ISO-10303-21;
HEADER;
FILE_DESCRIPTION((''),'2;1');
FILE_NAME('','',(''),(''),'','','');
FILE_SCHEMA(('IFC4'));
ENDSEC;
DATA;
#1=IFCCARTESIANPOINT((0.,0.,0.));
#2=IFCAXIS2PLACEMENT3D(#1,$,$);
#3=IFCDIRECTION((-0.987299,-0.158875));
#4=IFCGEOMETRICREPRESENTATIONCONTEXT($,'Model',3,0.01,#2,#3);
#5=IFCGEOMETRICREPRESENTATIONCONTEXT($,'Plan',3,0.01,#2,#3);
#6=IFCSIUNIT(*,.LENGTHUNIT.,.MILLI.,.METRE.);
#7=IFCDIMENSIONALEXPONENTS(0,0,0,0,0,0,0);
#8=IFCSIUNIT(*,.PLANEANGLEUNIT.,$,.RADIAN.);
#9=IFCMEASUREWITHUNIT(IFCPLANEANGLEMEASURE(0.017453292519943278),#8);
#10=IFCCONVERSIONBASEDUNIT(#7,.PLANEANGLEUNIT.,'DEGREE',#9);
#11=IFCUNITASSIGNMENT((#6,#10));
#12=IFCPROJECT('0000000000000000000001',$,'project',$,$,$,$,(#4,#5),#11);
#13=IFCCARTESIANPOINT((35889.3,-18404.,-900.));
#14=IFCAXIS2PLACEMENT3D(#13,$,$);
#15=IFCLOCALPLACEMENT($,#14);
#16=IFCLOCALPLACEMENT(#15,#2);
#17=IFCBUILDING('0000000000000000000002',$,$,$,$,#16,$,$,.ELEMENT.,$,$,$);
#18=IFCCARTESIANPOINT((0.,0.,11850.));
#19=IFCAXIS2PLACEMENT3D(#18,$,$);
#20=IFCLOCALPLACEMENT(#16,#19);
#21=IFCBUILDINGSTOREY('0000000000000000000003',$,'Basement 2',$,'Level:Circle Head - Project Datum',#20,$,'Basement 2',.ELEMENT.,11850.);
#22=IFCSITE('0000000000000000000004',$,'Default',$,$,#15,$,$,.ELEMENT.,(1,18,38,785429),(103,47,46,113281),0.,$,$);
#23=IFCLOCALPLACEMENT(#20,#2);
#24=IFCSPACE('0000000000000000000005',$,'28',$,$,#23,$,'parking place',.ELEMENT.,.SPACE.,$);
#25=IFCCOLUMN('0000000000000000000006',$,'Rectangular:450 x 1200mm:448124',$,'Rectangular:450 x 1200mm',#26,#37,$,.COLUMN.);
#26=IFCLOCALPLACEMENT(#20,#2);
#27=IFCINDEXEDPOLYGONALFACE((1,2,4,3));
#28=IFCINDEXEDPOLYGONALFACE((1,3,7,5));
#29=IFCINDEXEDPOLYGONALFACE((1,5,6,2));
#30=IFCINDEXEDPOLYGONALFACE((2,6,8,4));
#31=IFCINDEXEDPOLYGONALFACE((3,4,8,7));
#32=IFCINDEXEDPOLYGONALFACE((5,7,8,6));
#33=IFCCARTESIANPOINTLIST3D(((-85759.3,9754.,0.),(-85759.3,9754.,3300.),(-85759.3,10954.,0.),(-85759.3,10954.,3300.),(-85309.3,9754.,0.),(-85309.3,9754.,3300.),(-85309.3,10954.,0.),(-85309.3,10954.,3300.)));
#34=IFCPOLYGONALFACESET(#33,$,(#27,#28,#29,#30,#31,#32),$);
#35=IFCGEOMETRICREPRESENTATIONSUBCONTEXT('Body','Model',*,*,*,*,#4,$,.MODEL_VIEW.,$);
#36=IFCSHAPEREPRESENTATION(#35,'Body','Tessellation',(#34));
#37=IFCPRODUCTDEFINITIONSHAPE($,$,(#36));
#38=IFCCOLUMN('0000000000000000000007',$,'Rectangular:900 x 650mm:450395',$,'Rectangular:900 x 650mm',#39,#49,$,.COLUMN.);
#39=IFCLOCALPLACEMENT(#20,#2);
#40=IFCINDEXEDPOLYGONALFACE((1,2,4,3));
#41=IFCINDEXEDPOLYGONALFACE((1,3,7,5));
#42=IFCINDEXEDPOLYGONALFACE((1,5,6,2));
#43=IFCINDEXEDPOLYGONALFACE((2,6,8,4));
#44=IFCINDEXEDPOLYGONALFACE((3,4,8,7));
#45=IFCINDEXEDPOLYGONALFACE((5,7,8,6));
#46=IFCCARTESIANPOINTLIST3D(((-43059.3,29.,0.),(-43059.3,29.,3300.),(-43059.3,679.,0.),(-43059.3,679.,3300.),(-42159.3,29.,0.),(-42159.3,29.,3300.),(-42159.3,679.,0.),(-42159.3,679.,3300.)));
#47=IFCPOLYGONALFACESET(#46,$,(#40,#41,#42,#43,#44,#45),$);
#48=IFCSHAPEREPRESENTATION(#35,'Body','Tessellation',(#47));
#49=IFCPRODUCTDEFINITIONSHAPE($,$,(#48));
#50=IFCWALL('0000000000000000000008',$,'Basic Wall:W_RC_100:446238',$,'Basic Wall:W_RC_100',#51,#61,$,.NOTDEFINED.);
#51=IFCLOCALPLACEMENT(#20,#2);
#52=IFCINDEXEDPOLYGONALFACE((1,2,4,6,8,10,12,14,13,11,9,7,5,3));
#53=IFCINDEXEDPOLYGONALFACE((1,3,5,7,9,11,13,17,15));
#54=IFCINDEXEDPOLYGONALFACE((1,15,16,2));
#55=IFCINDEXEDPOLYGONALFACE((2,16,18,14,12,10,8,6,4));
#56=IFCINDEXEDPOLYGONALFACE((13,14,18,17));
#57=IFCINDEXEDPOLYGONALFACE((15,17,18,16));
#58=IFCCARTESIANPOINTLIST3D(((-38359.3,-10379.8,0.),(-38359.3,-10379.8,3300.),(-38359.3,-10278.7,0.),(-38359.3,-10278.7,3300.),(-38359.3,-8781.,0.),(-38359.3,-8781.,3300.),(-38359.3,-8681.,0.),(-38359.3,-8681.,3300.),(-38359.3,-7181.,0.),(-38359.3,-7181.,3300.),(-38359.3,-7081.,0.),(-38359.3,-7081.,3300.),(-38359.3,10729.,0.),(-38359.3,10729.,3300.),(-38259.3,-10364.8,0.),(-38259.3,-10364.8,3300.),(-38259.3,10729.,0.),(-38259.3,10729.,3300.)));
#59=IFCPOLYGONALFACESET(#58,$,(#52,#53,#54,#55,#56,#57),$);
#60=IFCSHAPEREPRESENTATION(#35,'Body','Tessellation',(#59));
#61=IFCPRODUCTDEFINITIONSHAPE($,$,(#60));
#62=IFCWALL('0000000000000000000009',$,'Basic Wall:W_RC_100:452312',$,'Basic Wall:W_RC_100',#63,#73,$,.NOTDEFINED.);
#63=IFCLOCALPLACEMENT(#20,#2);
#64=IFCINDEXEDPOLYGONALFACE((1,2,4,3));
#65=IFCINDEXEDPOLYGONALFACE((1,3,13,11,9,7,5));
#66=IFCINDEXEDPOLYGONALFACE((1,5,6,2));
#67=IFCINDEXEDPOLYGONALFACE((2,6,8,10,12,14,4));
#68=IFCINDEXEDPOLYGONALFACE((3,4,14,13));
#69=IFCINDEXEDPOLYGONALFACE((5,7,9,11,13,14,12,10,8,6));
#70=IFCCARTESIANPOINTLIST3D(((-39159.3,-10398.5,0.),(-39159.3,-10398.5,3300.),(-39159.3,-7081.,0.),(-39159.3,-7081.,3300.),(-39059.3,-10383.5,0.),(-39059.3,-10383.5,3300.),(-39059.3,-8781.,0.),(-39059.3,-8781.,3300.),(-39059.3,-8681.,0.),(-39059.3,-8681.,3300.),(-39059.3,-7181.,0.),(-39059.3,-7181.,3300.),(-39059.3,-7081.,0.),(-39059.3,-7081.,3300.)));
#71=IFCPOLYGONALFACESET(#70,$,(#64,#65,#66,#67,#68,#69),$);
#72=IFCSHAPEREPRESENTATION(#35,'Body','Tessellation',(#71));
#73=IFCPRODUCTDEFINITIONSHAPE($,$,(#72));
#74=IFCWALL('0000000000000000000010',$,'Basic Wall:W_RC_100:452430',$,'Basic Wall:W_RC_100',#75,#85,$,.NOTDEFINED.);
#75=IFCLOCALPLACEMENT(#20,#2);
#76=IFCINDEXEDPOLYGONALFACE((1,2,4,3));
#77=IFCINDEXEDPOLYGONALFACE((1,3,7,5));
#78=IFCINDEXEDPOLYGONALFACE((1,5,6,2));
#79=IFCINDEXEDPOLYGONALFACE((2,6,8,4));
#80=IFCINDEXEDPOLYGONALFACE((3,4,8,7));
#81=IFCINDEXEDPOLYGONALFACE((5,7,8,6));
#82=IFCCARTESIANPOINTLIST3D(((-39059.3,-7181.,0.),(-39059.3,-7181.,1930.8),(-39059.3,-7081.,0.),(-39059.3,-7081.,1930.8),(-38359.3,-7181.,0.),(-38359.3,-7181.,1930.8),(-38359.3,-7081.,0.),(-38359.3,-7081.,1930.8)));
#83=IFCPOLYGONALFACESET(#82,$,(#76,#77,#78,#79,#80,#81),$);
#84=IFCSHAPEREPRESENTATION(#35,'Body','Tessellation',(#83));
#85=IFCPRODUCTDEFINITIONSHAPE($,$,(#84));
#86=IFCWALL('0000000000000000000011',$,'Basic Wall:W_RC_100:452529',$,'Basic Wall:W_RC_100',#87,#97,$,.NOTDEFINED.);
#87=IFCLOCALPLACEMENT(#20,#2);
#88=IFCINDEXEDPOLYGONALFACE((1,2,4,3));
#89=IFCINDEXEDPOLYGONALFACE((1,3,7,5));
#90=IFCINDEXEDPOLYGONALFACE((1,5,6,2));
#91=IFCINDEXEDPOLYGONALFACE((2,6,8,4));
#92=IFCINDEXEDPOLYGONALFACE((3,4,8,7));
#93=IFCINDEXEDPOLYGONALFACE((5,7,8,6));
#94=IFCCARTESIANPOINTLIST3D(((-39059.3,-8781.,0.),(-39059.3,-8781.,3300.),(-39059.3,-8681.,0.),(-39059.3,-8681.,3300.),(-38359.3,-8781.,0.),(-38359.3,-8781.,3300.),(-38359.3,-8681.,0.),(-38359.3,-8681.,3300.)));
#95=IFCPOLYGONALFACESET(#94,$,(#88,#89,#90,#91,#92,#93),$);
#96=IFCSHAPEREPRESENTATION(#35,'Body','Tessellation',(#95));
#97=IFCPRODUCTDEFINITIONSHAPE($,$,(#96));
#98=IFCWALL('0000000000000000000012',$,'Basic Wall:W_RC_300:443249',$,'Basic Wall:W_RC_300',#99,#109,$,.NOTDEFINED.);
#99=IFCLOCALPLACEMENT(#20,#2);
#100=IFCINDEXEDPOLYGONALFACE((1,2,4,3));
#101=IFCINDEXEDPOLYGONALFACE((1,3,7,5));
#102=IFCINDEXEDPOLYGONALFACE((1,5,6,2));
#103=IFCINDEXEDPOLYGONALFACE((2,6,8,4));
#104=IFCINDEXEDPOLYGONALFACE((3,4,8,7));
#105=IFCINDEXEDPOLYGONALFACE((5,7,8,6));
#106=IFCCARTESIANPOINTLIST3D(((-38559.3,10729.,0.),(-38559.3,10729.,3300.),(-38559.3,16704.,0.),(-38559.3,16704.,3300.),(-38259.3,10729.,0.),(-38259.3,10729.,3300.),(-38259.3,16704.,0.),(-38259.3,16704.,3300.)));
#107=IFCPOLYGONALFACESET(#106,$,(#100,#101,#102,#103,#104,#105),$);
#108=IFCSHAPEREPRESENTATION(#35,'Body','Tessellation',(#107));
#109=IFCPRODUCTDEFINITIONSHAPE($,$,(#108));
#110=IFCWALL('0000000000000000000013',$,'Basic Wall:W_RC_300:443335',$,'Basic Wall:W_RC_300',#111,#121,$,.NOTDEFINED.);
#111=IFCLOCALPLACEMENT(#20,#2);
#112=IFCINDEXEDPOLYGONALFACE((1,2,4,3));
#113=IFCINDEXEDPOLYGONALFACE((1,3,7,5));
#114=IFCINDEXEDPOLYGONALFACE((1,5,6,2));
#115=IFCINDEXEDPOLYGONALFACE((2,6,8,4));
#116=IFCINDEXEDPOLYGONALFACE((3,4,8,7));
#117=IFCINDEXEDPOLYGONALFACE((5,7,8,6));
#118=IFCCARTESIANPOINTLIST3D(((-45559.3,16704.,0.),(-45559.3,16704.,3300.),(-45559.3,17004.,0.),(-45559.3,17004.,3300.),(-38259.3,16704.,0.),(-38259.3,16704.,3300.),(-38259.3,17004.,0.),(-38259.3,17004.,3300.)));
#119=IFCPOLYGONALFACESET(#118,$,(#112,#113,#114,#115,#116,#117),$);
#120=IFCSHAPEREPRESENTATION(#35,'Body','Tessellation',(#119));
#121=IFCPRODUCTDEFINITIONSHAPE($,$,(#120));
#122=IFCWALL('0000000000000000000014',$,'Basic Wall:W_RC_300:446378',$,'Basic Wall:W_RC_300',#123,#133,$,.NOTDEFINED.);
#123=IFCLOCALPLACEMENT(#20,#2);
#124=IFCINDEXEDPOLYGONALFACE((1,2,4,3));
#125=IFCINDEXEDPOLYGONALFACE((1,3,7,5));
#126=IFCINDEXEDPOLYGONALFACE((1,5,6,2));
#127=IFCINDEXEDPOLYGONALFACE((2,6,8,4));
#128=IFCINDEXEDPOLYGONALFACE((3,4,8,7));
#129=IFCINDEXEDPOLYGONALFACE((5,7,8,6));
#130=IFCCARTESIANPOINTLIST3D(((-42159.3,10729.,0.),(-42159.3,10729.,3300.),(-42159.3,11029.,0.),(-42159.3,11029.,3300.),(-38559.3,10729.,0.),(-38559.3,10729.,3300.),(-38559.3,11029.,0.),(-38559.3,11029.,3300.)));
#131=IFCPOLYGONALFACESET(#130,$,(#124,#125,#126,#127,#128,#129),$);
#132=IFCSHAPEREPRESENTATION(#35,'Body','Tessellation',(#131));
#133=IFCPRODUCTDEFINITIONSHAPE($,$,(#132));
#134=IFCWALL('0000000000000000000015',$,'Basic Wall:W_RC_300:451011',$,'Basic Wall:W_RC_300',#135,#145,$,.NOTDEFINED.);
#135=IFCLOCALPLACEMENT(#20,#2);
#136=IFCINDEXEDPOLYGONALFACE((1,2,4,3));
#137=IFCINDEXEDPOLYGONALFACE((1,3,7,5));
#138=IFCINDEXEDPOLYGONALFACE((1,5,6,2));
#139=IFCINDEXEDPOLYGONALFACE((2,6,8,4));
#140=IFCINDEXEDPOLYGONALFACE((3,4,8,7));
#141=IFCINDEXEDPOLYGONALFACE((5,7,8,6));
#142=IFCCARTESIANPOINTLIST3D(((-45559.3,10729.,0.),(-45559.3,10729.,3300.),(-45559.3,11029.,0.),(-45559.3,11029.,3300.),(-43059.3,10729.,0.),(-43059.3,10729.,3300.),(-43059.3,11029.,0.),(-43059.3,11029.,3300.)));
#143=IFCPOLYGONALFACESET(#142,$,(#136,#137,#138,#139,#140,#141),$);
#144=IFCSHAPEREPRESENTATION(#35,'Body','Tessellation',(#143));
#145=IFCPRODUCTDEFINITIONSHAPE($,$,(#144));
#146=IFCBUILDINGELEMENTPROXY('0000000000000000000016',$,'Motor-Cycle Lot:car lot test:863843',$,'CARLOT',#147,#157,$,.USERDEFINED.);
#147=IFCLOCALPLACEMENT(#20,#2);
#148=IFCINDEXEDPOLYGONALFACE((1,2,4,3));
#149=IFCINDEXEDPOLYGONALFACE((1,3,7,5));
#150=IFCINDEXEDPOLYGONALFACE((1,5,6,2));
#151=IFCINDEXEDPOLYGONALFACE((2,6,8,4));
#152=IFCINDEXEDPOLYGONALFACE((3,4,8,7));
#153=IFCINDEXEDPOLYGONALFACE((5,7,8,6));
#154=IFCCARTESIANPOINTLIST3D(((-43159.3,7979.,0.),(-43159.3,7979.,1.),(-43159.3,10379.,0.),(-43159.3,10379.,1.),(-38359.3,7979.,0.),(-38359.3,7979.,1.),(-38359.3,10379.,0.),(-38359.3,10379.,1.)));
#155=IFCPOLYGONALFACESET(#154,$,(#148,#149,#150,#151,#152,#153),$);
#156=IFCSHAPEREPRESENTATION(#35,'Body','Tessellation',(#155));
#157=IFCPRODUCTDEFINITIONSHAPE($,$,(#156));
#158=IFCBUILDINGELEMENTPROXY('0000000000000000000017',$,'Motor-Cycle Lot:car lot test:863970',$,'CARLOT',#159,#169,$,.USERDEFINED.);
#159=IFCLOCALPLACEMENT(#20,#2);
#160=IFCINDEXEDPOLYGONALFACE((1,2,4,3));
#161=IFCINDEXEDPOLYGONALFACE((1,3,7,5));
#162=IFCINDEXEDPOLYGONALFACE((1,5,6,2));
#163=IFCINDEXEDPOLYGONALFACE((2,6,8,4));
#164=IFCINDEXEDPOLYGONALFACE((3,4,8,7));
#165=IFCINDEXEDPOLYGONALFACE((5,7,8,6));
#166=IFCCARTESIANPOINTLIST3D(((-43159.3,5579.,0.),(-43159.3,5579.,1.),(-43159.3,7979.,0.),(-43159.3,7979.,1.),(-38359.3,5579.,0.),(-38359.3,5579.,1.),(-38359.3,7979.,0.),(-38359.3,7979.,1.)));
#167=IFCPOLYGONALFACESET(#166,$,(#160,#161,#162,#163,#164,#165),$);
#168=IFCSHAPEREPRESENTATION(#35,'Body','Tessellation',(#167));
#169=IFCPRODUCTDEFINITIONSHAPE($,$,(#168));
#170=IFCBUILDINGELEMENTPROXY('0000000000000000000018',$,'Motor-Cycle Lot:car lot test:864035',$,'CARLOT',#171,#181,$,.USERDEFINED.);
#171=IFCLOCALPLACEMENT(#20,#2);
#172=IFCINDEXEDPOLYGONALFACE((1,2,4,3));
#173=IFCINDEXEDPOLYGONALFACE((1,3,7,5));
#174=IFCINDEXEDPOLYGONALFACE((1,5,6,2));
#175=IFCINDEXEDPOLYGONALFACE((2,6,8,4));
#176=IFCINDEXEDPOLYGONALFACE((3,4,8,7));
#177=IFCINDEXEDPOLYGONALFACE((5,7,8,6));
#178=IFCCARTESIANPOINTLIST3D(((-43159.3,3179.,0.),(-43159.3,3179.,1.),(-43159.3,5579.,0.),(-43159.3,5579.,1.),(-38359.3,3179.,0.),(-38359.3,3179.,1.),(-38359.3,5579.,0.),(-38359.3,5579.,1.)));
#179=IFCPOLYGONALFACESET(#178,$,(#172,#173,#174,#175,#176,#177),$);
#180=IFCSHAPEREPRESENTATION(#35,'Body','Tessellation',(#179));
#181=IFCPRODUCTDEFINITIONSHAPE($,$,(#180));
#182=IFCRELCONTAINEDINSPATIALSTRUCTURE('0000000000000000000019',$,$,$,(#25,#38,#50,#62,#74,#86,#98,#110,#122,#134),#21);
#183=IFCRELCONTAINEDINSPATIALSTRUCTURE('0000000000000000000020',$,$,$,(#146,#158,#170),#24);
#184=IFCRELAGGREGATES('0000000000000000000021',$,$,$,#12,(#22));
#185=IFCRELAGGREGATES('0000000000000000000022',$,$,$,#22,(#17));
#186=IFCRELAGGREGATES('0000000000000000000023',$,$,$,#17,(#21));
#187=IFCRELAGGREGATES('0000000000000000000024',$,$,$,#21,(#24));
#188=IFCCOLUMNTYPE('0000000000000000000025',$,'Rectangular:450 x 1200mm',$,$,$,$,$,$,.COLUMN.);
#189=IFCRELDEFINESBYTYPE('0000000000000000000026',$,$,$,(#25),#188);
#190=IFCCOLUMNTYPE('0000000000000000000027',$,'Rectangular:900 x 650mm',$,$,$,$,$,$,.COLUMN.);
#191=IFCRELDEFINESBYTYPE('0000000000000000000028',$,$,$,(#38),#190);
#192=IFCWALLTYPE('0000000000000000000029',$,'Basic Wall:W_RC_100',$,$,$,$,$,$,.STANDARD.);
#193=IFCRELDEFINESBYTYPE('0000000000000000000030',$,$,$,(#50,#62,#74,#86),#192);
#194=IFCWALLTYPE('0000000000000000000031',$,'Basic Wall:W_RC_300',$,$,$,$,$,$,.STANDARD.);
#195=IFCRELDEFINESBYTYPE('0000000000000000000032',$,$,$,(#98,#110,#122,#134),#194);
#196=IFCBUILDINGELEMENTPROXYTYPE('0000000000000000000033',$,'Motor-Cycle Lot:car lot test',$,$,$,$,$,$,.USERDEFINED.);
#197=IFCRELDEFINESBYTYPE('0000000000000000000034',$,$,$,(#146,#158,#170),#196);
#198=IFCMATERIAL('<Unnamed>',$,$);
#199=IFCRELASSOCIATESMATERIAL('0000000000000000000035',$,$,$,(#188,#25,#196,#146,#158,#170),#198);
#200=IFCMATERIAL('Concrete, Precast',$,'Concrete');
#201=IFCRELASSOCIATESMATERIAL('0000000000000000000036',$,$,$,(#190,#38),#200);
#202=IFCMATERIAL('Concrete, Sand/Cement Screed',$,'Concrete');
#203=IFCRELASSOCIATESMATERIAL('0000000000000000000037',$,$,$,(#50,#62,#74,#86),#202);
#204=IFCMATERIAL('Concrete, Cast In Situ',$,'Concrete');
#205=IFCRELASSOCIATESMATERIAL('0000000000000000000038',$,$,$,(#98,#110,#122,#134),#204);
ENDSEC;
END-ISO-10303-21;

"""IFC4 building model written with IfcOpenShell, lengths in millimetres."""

from ifc_helpers import new_model, entity, si_unit, converted_unit, direction, frame, origin, place, context, subcontext, project, spatial, indexed_curve, outline, extrude, source, transform, mapped, material, type_object, type_shapes, element, save


model = new_model("IFC4")

# Units and contexts
model_context = context("Model", 3, precision=0.01, world=origin(), true_north=direction((-0.987299, -0.158875)))
plan_context = context("Plan", 3, precision=0.01, world=origin(), true_north=direction((-0.987299, -0.158875)))
body_context = subcontext(model_context, "Body", "Model", "MODEL_VIEW")
ifc_project = project(units=[si_unit("LENGTHUNIT", "METRE", prefix="MILLI"), converted_unit("PLANEANGLEUNIT", "DEGREE", entity("IfcPlaneAngleMeasure", 0.017453292519943278), si_unit("PLANEANGLEUNIT", "RADIAN"), dimensions=[0, 0, 0, 0, 0, 0, 0])], contexts=[model_context, plan_context])

# Site, building, storey
site_placement = place(None, frame((35889.3, -18404.0, -900.0)))
site = spatial("IfcSite", under=ifc_project, at=site_placement, Name="Default", CompositionType="ELEMENT", RefLatitude=(1, 18, 38, 785429), RefLongitude=(103, 47, 46, 113281), RefElevation=0.0)
building_placement = place(site_placement, origin())
building = spatial("IfcBuilding", under=site, at=building_placement, CompositionType="ELEMENT")
storey_placement = place(building_placement, frame((0.0, 0.0, 11850.0)))
storey = spatial("IfcBuildingStorey", under=building, at=storey_placement, Name="Basement 2", ObjectType="Level:Circle Head - Project Datum", LongName="Basement 2", CompositionType="ELEMENT", Elevation=11850.0)

# Columns
ifc_material_1 = material(Name="Concrete, Sand/Cement Screed", Category="Concrete")
ifc_material_2 = material(Name="Concrete, Cast In Situ", Category="Concrete")
ifc_material_3 = material(Name="<Unnamed>")
column_type_1 = type_object("IfcColumnType", Name="Rectangular:450 x 1200mm", PredefinedType="COLUMN", material=ifc_material_3)
shared_shape_1 = source(origin(), body_context, "Body", "SweptSolid", [
    extrude(outline(indexed_curve([(-600.0, -225.0), (600.0, -225.0), (600.0, 225.0), (-600.0, 225.0), (-600.0, -225.0)], self_intersect=False)), frame((-85534.3, 10354.0, 11850.0), z_axis=(0.0, 0.0, 1.0), x_axis=(0.0, 1.0, 0.0)), (0.0, 0.0, 1.0), 3300.0),
])
type_shapes(column_type_1, [shared_shape_1])
column_1_placement = place(storey_placement, frame((0.0, 0.0, -11850.0)))
element("IfcColumn", 1, at=column_1_placement, inside=storey, type_object=column_type_1, material=ifc_material_3, Name="Rectangular:450 x 1200mm:448124", ObjectType="Rectangular:450 x 1200mm", PredefinedType="COLUMN", context=body_context, shape_type="MappedRepresentation", body=[
    mapped(shared_shape_1, transform((0.0, 0.0, 0.0), scale=1.0)),
])
ifc_material_4 = material(Name="Concrete, Precast", Category="Concrete")
column_type_2 = type_object("IfcColumnType", Name="Rectangular:900 x 650mm", PredefinedType="COLUMN", material=ifc_material_4)
shared_shape_2 = source(origin(), body_context, "Body", "SweptSolid", [
    extrude(outline(indexed_curve([(-325.0, -450.0), (325.0, -450.0), (325.0, 450.0), (-325.0, 450.0), (-325.0, -450.0)], self_intersect=False)), frame((0.0, 0.0, 11850.0), z_axis=(0.0, 0.0, 1.0), x_axis=(-1.0, 0.0, 0.0)), (0.0, 0.0, 1.0), 3300.0),
])
type_shapes(column_type_2, [shared_shape_2])
column_2_placement = place(storey_placement, frame((-42609.3, 354.0, -11850.0), z_axis=(0.0, 0.0, 1.0), x_axis=(0.0, 1.0, 0.0)))
element("IfcColumn", 2, at=column_2_placement, inside=storey, type_object=column_type_2, material=ifc_material_4, Name="Rectangular:900 x 650mm:450395", ObjectType="Rectangular:900 x 650mm", PredefinedType="COLUMN", context=body_context, shape_type="MappedRepresentation", body=[
    mapped(shared_shape_2, transform((0.0, 0.0, 0.0), scale=1.0)),
])

# Walls
wall_type_1 = type_object("IfcWallType", Name="Basic Wall:W_RC_100", PredefinedType="STANDARD")
wall_1_placement = place(storey_placement, frame((-38309.3, 10729.0, 0.0), z_axis=(0.0, 0.0, 1.0), x_axis=(0.0, -1.0, 0.0)))
element("IfcWall", 3, at=wall_1_placement, inside=storey, type_object=wall_type_1, material=ifc_material_1, Name="Basic Wall:W_RC_100:446238", ObjectType="Basic Wall:W_RC_100", PredefinedType="NOTDEFINED", context=body_context, shape_type="SweptSolid", body=[
    extrude(outline(indexed_curve([(21108.8, -50.0), (21093.9, 50.0), (0.0, 50.0), (0.0, -50.0), (17810.0, -50.0), (17910.0, -50.0), (19410.0, -50.0), (19510.0, -50.0), (21007.7, -50.0), (21108.8, -50.0)], self_intersect=False)), origin(), (0.0, 0.0, 1.0), 3300.0),
])
wall_2_placement = place(storey_placement, frame((-39109.3, -7081.0, 0.0), z_axis=(0.0, 0.0, 1.0), x_axis=(0.0, -1.0, 0.0)))
element("IfcWall", 4, at=wall_2_placement, inside=storey, type_object=wall_type_1, material=ifc_material_1, Name="Basic Wall:W_RC_100:452312", ObjectType="Basic Wall:W_RC_100", PredefinedType="NOTDEFINED", context=body_context, shape_type="SweptSolid", body=[
    extrude(outline(indexed_curve([(3317.5, -50.0), (3302.6, 50.0), (1700.0, 50.0), (1600.0, 50.0), (100.0, 50.0), (0.0, 50.0), (0.0, -50.0), (3317.5, -50.0)], self_intersect=False)), origin(), (0.0, 0.0, 1.0), 3300.0),
])
wall_3_placement = place(storey_placement, frame((-38359.3, -7131.0, 0.0), z_axis=(0.0, 0.0, 1.0), x_axis=(-1.0, 0.0, 0.0)))
element("IfcWall", 5, at=wall_3_placement, inside=storey, type_object=wall_type_1, material=ifc_material_1, Name="Basic Wall:W_RC_100:452430", ObjectType="Basic Wall:W_RC_100", PredefinedType="NOTDEFINED", context=body_context, shape_type="SweptSolid", body=[
    extrude(outline(indexed_curve([(700.0, 50.0), (0.0, 50.0), (0.0, -50.0), (700.0, -50.0), (700.0, 50.0)], self_intersect=False)), origin(), (0.0, 0.0, 1.0), 1930.8),
])
wall_4_placement = place(storey_placement, frame((-38359.3, -8731.0, 0.0), z_axis=(0.0, 0.0, 1.0), x_axis=(-1.0, 0.0, 0.0)))
element("IfcWall", 6, at=wall_4_placement, inside=storey, type_object=wall_type_1, material=ifc_material_1, Name="Basic Wall:W_RC_100:452529", ObjectType="Basic Wall:W_RC_100", PredefinedType="NOTDEFINED", context=body_context, shape_type="SweptSolid", body=[
    extrude(outline(indexed_curve([(700.0, 50.0), (0.0, 50.0), (0.0, -50.0), (700.0, -50.0), (700.0, 50.0)], self_intersect=False)), origin(), (0.0, 0.0, 1.0), 3300.0),
])
wall_type_2 = type_object("IfcWallType", Name="Basic Wall:W_RC_300", PredefinedType="STANDARD")
wall_5_placement = place(storey_placement, frame((-38409.3, 16704.0, 0.0), z_axis=(0.0, 0.0, 1.0), x_axis=(0.0, -1.0, 0.0)))
element("IfcWall", 7, at=wall_5_placement, inside=storey, type_object=wall_type_2, material=ifc_material_2, Name="Basic Wall:W_RC_300:443249", ObjectType="Basic Wall:W_RC_300", PredefinedType="NOTDEFINED", context=body_context, shape_type="SweptSolid", body=[
    extrude(outline(indexed_curve([(5975.0, 150.0), (0.0, 150.0), (0.0, -150.0), (5975.0, -150.0), (5975.0, 150.0)], self_intersect=False)), origin(), (0.0, 0.0, 1.0), 3300.0),
])
wall_6_placement = place(storey_placement, frame((-38259.3, 16854.0, 0.0), z_axis=(0.0, 0.0, 1.0), x_axis=(-1.0, 0.0, 0.0)))
element("IfcWall", 8, at=wall_6_placement, inside=storey, type_object=wall_type_2, material=ifc_material_2, Name="Basic Wall:W_RC_300:443335", ObjectType="Basic Wall:W_RC_300", PredefinedType="NOTDEFINED", context=body_context, shape_type="SweptSolid", body=[
    extrude(outline(indexed_curve([(7300.0, 150.0), (0.0, 150.0), (0.0, -150.0), (7300.0, -150.0), (7300.0, 150.0)], self_intersect=False)), origin(), (0.0, 0.0, 1.0), 3300.0),
])
wall_7_placement = place(storey_placement, frame((-38559.3, 10879.0, 0.0), z_axis=(0.0, 0.0, 1.0), x_axis=(-1.0, 0.0, 0.0)))
element("IfcWall", 9, at=wall_7_placement, inside=storey, type_object=wall_type_2, material=ifc_material_2, Name="Basic Wall:W_RC_300:446378", ObjectType="Basic Wall:W_RC_300", PredefinedType="NOTDEFINED", context=body_context, shape_type="SweptSolid", body=[
    extrude(outline(indexed_curve([(3600.0, 150.0), (0.0, 150.0), (0.0, -150.0), (3600.0, -150.0), (3600.0, 150.0)], self_intersect=False)), origin(), (0.0, 0.0, 1.0), 3300.0),
])
wall_8_placement = place(storey_placement, frame((-43059.3, 10879.0, 0.0), z_axis=(0.0, 0.0, 1.0), x_axis=(-1.0, 0.0, 0.0)))
element("IfcWall", 10, at=wall_8_placement, inside=storey, type_object=wall_type_2, material=ifc_material_2, Name="Basic Wall:W_RC_300:451011", ObjectType="Basic Wall:W_RC_300", PredefinedType="NOTDEFINED", context=body_context, shape_type="SweptSolid", body=[
    extrude(outline(indexed_curve([(2500.0, 150.0), (0.0, 150.0), (0.0, -150.0), (2500.0, -150.0), (2500.0, 150.0)], self_intersect=False)), origin(), (0.0, 0.0, 1.0), 3300.0),
])

# Shared definitions
space_placement = place(storey_placement, origin())
space = spatial("IfcSpace", under=storey, at=space_placement, Name="28", LongName="parking place", CompositionType="ELEMENT", PredefinedType="SPACE")

# Building element proxies
building_element_proxy_type_1 = type_object("IfcBuildingElementProxyType", Name="Motor-Cycle Lot:car lot test", PredefinedType="USERDEFINED", material=ifc_material_3)
shared_shape_3 = source(origin(), body_context, "Body", "SweptSolid", [
    extrude(outline(indexed_curve([(-2400.0, -1200.0), (2400.0, -1200.0), (2400.0, 1200.0), (-2400.0, 1200.0), (-2400.0, -1200.0)], self_intersect=False)), frame((0.0, 0.0, 0.0), z_axis=(0.0, 0.0, 1.0), x_axis=(-1.0, 0.0, 0.0)), (0.0, 0.0, 1.0), 1.0),
])
type_shapes(building_element_proxy_type_1, [shared_shape_3])
for number, where, name in (
    (11, (-40759.3, 9179.0, 0.0), "Motor-Cycle Lot:car lot test:863843"),
    (12, (-40759.3, 6779.0, 0.0), "Motor-Cycle Lot:car lot test:863970"),
    (13, (-40759.3, 4379.0, 0.0), "Motor-Cycle Lot:car lot test:864035"),
):
    element("IfcBuildingElementProxy", number, at=place(space_placement, frame(where)), inside=space, type_object=building_element_proxy_type_1, material=ifc_material_3, Name=name, ObjectType="CARLOT", PredefinedType="USERDEFINED", context=body_context, shape_type="MappedRepresentation", body=[
        mapped(shared_shape_3, transform((0.0, 0.0, 0.0), scale=1.0)),
    ])

save(model, "model.ifc")
